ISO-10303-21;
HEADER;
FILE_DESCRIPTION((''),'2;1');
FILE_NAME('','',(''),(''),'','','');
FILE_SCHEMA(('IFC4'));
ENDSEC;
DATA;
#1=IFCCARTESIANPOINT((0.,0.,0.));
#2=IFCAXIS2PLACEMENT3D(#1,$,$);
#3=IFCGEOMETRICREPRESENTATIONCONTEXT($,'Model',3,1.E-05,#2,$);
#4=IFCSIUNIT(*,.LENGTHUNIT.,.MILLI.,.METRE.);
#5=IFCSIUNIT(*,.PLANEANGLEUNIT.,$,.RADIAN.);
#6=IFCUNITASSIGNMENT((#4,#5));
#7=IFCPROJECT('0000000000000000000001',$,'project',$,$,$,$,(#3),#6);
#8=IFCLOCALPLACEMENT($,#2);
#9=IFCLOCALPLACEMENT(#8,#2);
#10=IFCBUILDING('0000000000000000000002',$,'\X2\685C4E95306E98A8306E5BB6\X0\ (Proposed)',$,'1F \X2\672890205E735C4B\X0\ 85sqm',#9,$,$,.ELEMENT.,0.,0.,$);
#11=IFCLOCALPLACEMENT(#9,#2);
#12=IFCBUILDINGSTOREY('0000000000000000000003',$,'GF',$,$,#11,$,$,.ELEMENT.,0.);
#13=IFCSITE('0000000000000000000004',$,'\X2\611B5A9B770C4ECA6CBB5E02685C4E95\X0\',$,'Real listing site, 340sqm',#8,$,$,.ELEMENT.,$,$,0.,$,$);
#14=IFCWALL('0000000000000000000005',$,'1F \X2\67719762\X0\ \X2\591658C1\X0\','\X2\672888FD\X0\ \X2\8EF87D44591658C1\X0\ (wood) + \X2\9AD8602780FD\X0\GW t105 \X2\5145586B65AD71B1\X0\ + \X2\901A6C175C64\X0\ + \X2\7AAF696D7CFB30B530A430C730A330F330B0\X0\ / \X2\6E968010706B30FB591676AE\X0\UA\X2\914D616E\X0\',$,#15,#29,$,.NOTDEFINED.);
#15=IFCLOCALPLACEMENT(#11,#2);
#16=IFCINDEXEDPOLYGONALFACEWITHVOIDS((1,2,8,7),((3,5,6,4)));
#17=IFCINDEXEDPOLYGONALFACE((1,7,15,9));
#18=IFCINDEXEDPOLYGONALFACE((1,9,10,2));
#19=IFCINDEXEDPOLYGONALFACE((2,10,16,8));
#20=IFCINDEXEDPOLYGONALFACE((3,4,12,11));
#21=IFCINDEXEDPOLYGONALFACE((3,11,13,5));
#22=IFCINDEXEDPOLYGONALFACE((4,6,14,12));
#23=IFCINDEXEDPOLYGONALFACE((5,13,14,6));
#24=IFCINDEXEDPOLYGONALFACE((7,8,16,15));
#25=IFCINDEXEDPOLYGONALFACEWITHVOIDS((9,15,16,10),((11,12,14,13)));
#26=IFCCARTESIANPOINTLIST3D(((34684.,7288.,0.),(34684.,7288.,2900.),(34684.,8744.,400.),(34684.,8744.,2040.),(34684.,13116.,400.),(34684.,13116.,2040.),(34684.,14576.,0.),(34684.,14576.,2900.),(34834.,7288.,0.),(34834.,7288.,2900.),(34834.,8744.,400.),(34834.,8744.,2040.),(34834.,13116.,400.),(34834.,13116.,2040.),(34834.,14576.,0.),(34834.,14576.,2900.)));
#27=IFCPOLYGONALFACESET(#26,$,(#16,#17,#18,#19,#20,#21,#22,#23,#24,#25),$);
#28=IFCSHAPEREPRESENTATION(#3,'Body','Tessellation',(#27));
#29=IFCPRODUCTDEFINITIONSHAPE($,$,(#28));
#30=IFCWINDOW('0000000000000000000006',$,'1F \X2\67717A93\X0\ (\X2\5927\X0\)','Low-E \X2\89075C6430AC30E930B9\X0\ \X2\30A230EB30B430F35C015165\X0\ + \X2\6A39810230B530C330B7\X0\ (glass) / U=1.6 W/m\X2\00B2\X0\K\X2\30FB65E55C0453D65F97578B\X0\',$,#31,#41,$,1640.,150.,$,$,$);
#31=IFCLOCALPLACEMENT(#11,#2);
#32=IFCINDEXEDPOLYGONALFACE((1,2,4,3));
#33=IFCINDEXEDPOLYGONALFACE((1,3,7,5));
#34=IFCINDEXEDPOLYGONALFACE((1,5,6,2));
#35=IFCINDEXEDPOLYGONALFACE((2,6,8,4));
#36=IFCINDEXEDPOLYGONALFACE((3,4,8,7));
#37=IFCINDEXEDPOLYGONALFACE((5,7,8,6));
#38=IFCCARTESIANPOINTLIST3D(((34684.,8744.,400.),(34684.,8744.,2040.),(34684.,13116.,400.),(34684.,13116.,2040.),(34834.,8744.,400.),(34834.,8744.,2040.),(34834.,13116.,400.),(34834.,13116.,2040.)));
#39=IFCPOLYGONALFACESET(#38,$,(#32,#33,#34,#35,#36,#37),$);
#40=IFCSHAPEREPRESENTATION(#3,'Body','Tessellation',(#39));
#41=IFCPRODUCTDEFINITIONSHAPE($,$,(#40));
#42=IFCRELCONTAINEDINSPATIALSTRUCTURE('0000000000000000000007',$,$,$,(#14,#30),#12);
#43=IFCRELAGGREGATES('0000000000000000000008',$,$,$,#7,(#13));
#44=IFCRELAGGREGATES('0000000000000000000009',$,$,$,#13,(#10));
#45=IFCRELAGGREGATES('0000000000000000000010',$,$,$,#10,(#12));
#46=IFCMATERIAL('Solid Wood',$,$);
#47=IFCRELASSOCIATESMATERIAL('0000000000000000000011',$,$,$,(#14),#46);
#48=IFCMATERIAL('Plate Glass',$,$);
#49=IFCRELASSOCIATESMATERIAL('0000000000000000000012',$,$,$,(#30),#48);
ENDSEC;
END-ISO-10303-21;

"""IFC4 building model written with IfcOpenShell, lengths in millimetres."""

from ifc_helpers import new_model, si_unit, frame, frame_2d, origin, place, context, project, spatial, rectangle, extrude, material, element, fill, save


model = new_model("IFC4")

# Units and contexts
model_context = context("Model", 3, precision=1e-05, world=origin())
ifc_project = project(units=[si_unit("LENGTHUNIT", "METRE", prefix="MILLI"), si_unit("PLANEANGLEUNIT", "RADIAN")], contexts=[model_context])

# Site, building, storey
site_placement = place(None, origin())
site = spatial("IfcSite", under=ifc_project, at=site_placement, Name="愛媛県今治市桜井", ObjectType="Real listing site, 340sqm", CompositionType="ELEMENT", RefElevation=0.0)
building_placement = place(site_placement, origin())
building = spatial("IfcBuilding", under=site, at=building_placement, Name="桜井の風の家 (Proposed)", ObjectType="1F 木造平屋 85sqm", CompositionType="ELEMENT", ElevationOfRefHeight=0.0, ElevationOfTerrain=0.0)
storey_placement = place(building_placement, origin())
storey = spatial("IfcBuildingStorey", under=building, at=storey_placement, Name="GF", CompositionType="ELEMENT", Elevation=0.0)

# Wall, opening, window
ifc_material_1 = material(Name="Solid Wood")
wall_1_placement = place(storey_placement, frame((17342.0, 3644.0, 0.0)))
wall_1 = element("IfcWall", 1, at=wall_1_placement, inside=storey, material=ifc_material_1, Name="1F 東面 外壁", Description="木製 軸組外壁 (wood) + 高性能GW t105 充填断熱 + 通気層 + 窯業系サイディング / 準耐火・外皮UA配慮", PredefinedType="NOTDEFINED", context=model_context, shape_type="SweptSolid", body=[
    extrude(rectangle(XDim=150.0, YDim=7288.0, at=frame_2d((75.0, 3644.0))), frame((17342.0, 3644.0, 0.0)), (0.0, 0.0, 1.0), 2900.0),
])
opening_1_placement = place(storey_placement, frame((17342.0, 4372.0, 200.0)))
opening_1 = element("IfcOpeningElement", 2, at=opening_1_placement, cuts=wall_1, PredefinedType="NOTDEFINED", context=model_context, shape_type="SweptSolid", body=[
    extrude(rectangle(XDim=150.0, YDim=4372.0, at=frame_2d((75.0, 2186.0))), frame((17342.0, 4372.0, 200.0)), (0.0, 0.0, 1.0), 1640.0),
])
ifc_material_2 = material(Name="Plate Glass")
window_1_placement = place(storey_placement, frame((17342.0, 4372.0, 200.0)))
window_1 = element("IfcWindow", 3, at=window_1_placement, inside=storey, material=ifc_material_2, Name="1F 東窓 (大)", Description="Low-E 複層ガラス アルゴン封入 + 樹脂サッシ (glass) / U=1.6 W/m²K・日射取得型", OverallHeight=1640.0, OverallWidth=150.0, context=model_context, shape_type="SweptSolid", body=[
    extrude(rectangle(XDim=150.0, YDim=4372.0, at=frame_2d((75.0, 2186.0))), frame((17342.0, 4372.0, 200.0)), (0.0, 0.0, 1.0), 1640.0),
])
fill(opening_1, window_1)

save(model, "model.ifc")
